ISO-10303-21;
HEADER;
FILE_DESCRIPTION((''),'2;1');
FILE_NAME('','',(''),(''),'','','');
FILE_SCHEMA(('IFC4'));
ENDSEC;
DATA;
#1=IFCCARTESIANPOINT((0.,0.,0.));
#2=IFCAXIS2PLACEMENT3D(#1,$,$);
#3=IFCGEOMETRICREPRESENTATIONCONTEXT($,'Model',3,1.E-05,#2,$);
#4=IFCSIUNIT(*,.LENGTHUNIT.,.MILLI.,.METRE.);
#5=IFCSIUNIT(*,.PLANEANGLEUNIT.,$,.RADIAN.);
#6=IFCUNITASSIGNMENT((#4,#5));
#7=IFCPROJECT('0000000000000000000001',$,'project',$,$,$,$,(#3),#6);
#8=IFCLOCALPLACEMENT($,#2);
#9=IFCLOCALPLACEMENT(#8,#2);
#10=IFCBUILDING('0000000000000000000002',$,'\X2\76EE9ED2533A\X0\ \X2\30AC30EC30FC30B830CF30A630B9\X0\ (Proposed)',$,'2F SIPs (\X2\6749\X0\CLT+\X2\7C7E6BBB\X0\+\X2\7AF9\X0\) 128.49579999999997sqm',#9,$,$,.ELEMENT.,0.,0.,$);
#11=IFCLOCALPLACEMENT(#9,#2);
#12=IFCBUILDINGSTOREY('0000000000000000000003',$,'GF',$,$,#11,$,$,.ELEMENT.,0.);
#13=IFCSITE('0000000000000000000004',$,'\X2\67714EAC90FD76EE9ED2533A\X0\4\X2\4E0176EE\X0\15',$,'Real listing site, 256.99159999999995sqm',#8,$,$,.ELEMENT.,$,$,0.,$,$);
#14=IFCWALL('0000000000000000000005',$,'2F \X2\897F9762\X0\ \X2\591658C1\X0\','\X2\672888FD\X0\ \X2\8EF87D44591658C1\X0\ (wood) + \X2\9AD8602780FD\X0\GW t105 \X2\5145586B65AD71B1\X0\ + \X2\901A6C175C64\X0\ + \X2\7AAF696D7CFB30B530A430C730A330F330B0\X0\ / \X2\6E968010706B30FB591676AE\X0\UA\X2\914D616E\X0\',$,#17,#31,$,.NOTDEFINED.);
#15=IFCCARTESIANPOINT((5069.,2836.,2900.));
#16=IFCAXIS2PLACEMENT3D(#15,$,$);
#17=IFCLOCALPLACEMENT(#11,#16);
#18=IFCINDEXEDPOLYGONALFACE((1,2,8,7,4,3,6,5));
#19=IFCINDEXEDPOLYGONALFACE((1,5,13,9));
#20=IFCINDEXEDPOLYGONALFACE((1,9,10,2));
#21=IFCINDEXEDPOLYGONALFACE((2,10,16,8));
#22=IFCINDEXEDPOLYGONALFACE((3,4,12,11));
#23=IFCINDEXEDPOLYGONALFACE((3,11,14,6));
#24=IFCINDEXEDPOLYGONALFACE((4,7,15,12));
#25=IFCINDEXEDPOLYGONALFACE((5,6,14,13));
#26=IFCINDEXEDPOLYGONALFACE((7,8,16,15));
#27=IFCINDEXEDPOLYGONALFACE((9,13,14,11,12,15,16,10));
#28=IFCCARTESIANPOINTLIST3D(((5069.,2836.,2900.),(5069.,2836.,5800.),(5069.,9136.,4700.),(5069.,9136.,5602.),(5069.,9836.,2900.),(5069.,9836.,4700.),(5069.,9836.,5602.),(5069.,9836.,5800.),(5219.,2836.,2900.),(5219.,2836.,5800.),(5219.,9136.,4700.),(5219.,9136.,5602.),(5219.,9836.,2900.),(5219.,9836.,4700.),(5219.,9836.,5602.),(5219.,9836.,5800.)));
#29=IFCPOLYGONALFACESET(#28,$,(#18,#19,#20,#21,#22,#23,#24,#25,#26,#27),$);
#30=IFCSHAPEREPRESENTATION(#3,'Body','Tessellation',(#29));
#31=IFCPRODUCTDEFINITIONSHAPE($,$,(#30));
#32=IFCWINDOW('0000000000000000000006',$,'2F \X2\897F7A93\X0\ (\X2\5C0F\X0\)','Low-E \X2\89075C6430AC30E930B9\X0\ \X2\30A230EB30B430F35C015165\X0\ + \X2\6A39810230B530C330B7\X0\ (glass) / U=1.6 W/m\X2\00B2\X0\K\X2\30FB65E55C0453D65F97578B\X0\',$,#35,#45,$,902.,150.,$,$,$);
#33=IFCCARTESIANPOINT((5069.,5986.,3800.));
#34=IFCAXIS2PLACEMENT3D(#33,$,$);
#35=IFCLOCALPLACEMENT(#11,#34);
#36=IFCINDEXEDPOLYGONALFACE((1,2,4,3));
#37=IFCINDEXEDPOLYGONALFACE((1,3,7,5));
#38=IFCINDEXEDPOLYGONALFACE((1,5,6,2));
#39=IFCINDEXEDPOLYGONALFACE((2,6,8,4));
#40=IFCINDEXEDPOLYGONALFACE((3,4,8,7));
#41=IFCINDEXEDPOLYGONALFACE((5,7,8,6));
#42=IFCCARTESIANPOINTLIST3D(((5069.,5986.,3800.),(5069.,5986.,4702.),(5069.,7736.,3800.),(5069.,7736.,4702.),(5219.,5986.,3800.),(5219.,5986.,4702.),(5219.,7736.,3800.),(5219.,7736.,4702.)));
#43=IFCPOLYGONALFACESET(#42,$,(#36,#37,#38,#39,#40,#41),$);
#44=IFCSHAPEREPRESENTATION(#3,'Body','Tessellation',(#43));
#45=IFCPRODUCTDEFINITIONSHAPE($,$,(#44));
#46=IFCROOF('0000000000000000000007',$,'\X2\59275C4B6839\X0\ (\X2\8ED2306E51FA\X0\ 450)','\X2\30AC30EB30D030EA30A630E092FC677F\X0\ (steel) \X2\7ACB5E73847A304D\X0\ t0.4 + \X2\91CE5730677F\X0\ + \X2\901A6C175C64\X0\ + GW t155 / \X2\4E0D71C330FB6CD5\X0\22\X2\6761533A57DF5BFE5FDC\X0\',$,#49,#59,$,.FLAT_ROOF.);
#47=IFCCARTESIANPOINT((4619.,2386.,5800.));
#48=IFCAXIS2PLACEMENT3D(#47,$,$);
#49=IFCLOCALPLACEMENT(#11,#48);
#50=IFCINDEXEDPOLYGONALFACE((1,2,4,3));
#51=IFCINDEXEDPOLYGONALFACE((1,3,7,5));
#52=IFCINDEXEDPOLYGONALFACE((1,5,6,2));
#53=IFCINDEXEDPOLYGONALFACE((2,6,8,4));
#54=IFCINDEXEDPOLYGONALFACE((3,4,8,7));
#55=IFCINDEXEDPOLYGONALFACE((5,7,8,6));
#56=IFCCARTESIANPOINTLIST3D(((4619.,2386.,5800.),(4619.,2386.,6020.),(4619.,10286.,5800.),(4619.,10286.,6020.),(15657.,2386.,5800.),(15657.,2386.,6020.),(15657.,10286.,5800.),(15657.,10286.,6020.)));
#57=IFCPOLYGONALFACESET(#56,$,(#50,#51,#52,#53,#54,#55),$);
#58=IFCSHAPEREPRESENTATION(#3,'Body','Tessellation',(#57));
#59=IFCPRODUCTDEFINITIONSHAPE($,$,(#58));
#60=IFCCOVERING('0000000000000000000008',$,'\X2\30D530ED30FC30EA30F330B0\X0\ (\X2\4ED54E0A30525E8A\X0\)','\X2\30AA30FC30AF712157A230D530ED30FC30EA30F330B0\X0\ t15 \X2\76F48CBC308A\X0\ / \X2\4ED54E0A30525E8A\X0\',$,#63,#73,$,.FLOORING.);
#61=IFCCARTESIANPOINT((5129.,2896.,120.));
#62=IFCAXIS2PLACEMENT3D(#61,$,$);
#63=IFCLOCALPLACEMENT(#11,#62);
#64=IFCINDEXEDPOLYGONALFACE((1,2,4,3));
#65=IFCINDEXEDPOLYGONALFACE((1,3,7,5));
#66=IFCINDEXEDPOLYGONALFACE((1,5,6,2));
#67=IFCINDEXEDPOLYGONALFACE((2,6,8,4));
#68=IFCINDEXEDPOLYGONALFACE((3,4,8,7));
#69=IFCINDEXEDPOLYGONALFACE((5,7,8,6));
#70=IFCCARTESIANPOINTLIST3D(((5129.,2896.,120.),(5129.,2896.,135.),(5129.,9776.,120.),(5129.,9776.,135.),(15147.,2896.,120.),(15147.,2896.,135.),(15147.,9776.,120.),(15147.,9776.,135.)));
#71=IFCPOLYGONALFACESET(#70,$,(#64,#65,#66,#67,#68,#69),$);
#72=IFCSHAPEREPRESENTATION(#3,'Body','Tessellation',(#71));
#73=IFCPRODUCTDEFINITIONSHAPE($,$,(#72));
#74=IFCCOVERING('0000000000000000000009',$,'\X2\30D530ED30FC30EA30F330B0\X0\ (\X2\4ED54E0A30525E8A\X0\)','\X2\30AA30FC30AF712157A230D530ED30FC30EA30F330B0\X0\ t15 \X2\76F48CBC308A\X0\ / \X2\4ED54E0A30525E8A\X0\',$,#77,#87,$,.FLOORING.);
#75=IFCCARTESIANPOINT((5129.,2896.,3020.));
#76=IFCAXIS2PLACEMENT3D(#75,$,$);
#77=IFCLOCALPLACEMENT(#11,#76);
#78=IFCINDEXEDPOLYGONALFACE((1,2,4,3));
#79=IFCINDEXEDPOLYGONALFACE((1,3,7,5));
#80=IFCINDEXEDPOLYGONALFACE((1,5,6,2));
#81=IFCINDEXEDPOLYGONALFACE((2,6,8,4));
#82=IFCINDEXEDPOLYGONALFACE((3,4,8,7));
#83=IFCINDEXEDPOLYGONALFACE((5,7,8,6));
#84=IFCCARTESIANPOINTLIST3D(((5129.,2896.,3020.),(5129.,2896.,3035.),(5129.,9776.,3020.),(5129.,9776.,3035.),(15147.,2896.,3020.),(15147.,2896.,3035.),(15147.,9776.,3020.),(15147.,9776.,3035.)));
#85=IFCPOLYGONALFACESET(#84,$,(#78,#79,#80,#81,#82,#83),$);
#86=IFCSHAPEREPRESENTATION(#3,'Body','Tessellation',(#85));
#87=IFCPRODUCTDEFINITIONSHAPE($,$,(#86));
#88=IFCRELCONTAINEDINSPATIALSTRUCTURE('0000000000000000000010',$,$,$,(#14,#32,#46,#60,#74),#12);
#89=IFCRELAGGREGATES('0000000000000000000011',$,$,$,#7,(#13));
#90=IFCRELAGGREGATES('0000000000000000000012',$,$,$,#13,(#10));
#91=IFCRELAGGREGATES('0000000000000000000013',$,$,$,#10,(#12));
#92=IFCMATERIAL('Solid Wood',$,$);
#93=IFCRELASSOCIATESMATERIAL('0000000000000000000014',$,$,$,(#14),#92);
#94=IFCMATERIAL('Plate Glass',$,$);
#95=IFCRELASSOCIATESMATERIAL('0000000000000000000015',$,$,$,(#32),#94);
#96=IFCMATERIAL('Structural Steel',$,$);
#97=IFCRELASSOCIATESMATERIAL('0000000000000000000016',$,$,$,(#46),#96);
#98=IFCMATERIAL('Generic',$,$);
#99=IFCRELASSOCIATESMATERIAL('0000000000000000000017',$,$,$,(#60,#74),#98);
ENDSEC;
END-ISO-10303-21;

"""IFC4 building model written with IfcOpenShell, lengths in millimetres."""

from ifc_helpers import new_model, si_unit, frame, frame_2d, origin, place, context, project, spatial, rectangle, extrude, material, element, fill, save


model = new_model("IFC4")

# Units and contexts
model_context = context("Model", 3, precision=1e-05, world=origin())
ifc_project = project(units=[si_unit("LENGTHUNIT", "METRE", prefix="MILLI"), si_unit("PLANEANGLEUNIT", "RADIAN")], contexts=[model_context])

# Site, building, storey
site_placement = place(None, origin())
site = spatial("IfcSite", under=ifc_project, at=site_placement, Name="東京都目黒区4丁目15", ObjectType="Real listing site, 256.99159999999995sqm", CompositionType="ELEMENT", RefElevation=0.0)
building_placement = place(site_placement, origin())
building = spatial("IfcBuilding", under=site, at=building_placement, Name="目黒区 ガレージハウス (Proposed)", ObjectType="2F SIPs (杉CLT+籾殻+竹) 128.49579999999997sqm", CompositionType="ELEMENT", ElevationOfRefHeight=0.0, ElevationOfTerrain=0.0)
storey_placement = place(building_placement, origin())
storey = spatial("IfcBuildingStorey", under=building, at=storey_placement, Name="GF", CompositionType="ELEMENT", Elevation=0.0)

# Shared definitions
ifc_material_1 = material(Name="Solid Wood")

# Shared definitions
ifc_material_2 = material(Name="Plate Glass")

# Wall, opening, window
wall_1_placement = place(storey_placement, frame((5069.0, 2836.0, 2900.0)))
wall_1 = element("IfcWall", 1, at=wall_1_placement, inside=storey, material=ifc_material_1, Name="2F 西面 外壁", Description="木製 軸組外壁 (wood) + 高性能GW t105 充填断熱 + 通気層 + 窯業系サイディング / 準耐火・外皮UA配慮", PredefinedType="NOTDEFINED", context=model_context, shape_type="SweptSolid", body=[
    extrude(rectangle(XDim=150.0, YDim=7000.0, at=frame_2d((75.0, 3500.0))), frame((5069.0, 2836.0, 2900.0)), (0.0, 0.0, 1.0), 2900.0),
])
opening_1_placement = place(storey_placement, frame((5069.0, 5986.0, 3800.0)))
opening_1 = element("IfcOpeningElement", 2, at=opening_1_placement, cuts=wall_1, PredefinedType="NOTDEFINED", context=model_context, shape_type="SweptSolid", body=[
    extrude(rectangle(XDim=150.0, YDim=1750.0, at=frame_2d((75.0, 875.0))), frame((5069.0, 5986.0, 3800.0)), (0.0, 0.0, 1.0), 902.0),
])
window_1_placement = place(storey_placement, frame((5069.0, 5986.0, 3800.0)))
window_1 = element("IfcWindow", 3, at=window_1_placement, inside=storey, material=ifc_material_2, Name="2F 西窓 (小)", Description="Low-E 複層ガラス アルゴン封入 + 樹脂サッシ (glass) / U=1.6 W/m²K・日射取得型", OverallHeight=902.0, OverallWidth=150.0, context=model_context, shape_type="SweptSolid", body=[
    extrude(rectangle(XDim=150.0, YDim=1750.0, at=frame_2d((75.0, 875.0))), frame((5069.0, 5986.0, 3800.0)), (0.0, 0.0, 1.0), 902.0),
])
fill(opening_1, window_1)

# Roof
ifc_material_3 = material(Name="Structural Steel")
roof_placement = place(storey_placement, frame((4619.0, 2386.0, 5800.0)))
element("IfcRoof", 4, at=roof_placement, inside=storey, material=ifc_material_3, Name="大屋根 (軒の出 450)", Description="ガルバリウム鋼板 (steel) 立平葺き t0.4 + 野地板 + 通気層 + GW t155 / 不燃・法22条区域対応", PredefinedType="FLAT_ROOF", context=model_context, shape_type="SweptSolid", body=[
    extrude(rectangle(XDim=11038.0, YDim=7900.0, at=frame_2d((5519.0, 3950.0))), frame((4619.0, 2386.0, 5800.0)), (0.0, 0.0, 1.0), 220.0),
])

# Coverings
ifc_material_4 = material(Name="Generic")
covering_1_placement = place(storey_placement, frame((5129.0, 2896.0, 120.0)))
element("IfcCovering", 5, at=covering_1_placement, inside=storey, material=ifc_material_4, Name="フローリング (仕上げ床)", Description="オーク無垢フローリング t15 直貼り / 仕上げ床", PredefinedType="FLOORING", context=model_context, shape_type="SweptSolid", body=[
    extrude(rectangle(XDim=10018.0, YDim=6880.0, at=frame_2d((5009.0, 3440.0))), frame((5129.0, 2896.0, 120.0)), (0.0, 0.0, 1.0), 15.0),
])
covering_2_placement = place(storey_placement, frame((5129.0, 2896.0, 3020.0)))
element("IfcCovering", 6, at=covering_2_placement, inside=storey, material=ifc_material_4, Name="フローリング (仕上げ床)", Description="オーク無垢フローリング t15 直貼り / 仕上げ床", PredefinedType="FLOORING", context=model_context, shape_type="SweptSolid", body=[
    extrude(rectangle(XDim=10018.0, YDim=6880.0, at=frame_2d((5009.0, 3440.0))), frame((5129.0, 2896.0, 3020.0)), (0.0, 0.0, 1.0), 15.0),
])

save(model, "model.ifc")
